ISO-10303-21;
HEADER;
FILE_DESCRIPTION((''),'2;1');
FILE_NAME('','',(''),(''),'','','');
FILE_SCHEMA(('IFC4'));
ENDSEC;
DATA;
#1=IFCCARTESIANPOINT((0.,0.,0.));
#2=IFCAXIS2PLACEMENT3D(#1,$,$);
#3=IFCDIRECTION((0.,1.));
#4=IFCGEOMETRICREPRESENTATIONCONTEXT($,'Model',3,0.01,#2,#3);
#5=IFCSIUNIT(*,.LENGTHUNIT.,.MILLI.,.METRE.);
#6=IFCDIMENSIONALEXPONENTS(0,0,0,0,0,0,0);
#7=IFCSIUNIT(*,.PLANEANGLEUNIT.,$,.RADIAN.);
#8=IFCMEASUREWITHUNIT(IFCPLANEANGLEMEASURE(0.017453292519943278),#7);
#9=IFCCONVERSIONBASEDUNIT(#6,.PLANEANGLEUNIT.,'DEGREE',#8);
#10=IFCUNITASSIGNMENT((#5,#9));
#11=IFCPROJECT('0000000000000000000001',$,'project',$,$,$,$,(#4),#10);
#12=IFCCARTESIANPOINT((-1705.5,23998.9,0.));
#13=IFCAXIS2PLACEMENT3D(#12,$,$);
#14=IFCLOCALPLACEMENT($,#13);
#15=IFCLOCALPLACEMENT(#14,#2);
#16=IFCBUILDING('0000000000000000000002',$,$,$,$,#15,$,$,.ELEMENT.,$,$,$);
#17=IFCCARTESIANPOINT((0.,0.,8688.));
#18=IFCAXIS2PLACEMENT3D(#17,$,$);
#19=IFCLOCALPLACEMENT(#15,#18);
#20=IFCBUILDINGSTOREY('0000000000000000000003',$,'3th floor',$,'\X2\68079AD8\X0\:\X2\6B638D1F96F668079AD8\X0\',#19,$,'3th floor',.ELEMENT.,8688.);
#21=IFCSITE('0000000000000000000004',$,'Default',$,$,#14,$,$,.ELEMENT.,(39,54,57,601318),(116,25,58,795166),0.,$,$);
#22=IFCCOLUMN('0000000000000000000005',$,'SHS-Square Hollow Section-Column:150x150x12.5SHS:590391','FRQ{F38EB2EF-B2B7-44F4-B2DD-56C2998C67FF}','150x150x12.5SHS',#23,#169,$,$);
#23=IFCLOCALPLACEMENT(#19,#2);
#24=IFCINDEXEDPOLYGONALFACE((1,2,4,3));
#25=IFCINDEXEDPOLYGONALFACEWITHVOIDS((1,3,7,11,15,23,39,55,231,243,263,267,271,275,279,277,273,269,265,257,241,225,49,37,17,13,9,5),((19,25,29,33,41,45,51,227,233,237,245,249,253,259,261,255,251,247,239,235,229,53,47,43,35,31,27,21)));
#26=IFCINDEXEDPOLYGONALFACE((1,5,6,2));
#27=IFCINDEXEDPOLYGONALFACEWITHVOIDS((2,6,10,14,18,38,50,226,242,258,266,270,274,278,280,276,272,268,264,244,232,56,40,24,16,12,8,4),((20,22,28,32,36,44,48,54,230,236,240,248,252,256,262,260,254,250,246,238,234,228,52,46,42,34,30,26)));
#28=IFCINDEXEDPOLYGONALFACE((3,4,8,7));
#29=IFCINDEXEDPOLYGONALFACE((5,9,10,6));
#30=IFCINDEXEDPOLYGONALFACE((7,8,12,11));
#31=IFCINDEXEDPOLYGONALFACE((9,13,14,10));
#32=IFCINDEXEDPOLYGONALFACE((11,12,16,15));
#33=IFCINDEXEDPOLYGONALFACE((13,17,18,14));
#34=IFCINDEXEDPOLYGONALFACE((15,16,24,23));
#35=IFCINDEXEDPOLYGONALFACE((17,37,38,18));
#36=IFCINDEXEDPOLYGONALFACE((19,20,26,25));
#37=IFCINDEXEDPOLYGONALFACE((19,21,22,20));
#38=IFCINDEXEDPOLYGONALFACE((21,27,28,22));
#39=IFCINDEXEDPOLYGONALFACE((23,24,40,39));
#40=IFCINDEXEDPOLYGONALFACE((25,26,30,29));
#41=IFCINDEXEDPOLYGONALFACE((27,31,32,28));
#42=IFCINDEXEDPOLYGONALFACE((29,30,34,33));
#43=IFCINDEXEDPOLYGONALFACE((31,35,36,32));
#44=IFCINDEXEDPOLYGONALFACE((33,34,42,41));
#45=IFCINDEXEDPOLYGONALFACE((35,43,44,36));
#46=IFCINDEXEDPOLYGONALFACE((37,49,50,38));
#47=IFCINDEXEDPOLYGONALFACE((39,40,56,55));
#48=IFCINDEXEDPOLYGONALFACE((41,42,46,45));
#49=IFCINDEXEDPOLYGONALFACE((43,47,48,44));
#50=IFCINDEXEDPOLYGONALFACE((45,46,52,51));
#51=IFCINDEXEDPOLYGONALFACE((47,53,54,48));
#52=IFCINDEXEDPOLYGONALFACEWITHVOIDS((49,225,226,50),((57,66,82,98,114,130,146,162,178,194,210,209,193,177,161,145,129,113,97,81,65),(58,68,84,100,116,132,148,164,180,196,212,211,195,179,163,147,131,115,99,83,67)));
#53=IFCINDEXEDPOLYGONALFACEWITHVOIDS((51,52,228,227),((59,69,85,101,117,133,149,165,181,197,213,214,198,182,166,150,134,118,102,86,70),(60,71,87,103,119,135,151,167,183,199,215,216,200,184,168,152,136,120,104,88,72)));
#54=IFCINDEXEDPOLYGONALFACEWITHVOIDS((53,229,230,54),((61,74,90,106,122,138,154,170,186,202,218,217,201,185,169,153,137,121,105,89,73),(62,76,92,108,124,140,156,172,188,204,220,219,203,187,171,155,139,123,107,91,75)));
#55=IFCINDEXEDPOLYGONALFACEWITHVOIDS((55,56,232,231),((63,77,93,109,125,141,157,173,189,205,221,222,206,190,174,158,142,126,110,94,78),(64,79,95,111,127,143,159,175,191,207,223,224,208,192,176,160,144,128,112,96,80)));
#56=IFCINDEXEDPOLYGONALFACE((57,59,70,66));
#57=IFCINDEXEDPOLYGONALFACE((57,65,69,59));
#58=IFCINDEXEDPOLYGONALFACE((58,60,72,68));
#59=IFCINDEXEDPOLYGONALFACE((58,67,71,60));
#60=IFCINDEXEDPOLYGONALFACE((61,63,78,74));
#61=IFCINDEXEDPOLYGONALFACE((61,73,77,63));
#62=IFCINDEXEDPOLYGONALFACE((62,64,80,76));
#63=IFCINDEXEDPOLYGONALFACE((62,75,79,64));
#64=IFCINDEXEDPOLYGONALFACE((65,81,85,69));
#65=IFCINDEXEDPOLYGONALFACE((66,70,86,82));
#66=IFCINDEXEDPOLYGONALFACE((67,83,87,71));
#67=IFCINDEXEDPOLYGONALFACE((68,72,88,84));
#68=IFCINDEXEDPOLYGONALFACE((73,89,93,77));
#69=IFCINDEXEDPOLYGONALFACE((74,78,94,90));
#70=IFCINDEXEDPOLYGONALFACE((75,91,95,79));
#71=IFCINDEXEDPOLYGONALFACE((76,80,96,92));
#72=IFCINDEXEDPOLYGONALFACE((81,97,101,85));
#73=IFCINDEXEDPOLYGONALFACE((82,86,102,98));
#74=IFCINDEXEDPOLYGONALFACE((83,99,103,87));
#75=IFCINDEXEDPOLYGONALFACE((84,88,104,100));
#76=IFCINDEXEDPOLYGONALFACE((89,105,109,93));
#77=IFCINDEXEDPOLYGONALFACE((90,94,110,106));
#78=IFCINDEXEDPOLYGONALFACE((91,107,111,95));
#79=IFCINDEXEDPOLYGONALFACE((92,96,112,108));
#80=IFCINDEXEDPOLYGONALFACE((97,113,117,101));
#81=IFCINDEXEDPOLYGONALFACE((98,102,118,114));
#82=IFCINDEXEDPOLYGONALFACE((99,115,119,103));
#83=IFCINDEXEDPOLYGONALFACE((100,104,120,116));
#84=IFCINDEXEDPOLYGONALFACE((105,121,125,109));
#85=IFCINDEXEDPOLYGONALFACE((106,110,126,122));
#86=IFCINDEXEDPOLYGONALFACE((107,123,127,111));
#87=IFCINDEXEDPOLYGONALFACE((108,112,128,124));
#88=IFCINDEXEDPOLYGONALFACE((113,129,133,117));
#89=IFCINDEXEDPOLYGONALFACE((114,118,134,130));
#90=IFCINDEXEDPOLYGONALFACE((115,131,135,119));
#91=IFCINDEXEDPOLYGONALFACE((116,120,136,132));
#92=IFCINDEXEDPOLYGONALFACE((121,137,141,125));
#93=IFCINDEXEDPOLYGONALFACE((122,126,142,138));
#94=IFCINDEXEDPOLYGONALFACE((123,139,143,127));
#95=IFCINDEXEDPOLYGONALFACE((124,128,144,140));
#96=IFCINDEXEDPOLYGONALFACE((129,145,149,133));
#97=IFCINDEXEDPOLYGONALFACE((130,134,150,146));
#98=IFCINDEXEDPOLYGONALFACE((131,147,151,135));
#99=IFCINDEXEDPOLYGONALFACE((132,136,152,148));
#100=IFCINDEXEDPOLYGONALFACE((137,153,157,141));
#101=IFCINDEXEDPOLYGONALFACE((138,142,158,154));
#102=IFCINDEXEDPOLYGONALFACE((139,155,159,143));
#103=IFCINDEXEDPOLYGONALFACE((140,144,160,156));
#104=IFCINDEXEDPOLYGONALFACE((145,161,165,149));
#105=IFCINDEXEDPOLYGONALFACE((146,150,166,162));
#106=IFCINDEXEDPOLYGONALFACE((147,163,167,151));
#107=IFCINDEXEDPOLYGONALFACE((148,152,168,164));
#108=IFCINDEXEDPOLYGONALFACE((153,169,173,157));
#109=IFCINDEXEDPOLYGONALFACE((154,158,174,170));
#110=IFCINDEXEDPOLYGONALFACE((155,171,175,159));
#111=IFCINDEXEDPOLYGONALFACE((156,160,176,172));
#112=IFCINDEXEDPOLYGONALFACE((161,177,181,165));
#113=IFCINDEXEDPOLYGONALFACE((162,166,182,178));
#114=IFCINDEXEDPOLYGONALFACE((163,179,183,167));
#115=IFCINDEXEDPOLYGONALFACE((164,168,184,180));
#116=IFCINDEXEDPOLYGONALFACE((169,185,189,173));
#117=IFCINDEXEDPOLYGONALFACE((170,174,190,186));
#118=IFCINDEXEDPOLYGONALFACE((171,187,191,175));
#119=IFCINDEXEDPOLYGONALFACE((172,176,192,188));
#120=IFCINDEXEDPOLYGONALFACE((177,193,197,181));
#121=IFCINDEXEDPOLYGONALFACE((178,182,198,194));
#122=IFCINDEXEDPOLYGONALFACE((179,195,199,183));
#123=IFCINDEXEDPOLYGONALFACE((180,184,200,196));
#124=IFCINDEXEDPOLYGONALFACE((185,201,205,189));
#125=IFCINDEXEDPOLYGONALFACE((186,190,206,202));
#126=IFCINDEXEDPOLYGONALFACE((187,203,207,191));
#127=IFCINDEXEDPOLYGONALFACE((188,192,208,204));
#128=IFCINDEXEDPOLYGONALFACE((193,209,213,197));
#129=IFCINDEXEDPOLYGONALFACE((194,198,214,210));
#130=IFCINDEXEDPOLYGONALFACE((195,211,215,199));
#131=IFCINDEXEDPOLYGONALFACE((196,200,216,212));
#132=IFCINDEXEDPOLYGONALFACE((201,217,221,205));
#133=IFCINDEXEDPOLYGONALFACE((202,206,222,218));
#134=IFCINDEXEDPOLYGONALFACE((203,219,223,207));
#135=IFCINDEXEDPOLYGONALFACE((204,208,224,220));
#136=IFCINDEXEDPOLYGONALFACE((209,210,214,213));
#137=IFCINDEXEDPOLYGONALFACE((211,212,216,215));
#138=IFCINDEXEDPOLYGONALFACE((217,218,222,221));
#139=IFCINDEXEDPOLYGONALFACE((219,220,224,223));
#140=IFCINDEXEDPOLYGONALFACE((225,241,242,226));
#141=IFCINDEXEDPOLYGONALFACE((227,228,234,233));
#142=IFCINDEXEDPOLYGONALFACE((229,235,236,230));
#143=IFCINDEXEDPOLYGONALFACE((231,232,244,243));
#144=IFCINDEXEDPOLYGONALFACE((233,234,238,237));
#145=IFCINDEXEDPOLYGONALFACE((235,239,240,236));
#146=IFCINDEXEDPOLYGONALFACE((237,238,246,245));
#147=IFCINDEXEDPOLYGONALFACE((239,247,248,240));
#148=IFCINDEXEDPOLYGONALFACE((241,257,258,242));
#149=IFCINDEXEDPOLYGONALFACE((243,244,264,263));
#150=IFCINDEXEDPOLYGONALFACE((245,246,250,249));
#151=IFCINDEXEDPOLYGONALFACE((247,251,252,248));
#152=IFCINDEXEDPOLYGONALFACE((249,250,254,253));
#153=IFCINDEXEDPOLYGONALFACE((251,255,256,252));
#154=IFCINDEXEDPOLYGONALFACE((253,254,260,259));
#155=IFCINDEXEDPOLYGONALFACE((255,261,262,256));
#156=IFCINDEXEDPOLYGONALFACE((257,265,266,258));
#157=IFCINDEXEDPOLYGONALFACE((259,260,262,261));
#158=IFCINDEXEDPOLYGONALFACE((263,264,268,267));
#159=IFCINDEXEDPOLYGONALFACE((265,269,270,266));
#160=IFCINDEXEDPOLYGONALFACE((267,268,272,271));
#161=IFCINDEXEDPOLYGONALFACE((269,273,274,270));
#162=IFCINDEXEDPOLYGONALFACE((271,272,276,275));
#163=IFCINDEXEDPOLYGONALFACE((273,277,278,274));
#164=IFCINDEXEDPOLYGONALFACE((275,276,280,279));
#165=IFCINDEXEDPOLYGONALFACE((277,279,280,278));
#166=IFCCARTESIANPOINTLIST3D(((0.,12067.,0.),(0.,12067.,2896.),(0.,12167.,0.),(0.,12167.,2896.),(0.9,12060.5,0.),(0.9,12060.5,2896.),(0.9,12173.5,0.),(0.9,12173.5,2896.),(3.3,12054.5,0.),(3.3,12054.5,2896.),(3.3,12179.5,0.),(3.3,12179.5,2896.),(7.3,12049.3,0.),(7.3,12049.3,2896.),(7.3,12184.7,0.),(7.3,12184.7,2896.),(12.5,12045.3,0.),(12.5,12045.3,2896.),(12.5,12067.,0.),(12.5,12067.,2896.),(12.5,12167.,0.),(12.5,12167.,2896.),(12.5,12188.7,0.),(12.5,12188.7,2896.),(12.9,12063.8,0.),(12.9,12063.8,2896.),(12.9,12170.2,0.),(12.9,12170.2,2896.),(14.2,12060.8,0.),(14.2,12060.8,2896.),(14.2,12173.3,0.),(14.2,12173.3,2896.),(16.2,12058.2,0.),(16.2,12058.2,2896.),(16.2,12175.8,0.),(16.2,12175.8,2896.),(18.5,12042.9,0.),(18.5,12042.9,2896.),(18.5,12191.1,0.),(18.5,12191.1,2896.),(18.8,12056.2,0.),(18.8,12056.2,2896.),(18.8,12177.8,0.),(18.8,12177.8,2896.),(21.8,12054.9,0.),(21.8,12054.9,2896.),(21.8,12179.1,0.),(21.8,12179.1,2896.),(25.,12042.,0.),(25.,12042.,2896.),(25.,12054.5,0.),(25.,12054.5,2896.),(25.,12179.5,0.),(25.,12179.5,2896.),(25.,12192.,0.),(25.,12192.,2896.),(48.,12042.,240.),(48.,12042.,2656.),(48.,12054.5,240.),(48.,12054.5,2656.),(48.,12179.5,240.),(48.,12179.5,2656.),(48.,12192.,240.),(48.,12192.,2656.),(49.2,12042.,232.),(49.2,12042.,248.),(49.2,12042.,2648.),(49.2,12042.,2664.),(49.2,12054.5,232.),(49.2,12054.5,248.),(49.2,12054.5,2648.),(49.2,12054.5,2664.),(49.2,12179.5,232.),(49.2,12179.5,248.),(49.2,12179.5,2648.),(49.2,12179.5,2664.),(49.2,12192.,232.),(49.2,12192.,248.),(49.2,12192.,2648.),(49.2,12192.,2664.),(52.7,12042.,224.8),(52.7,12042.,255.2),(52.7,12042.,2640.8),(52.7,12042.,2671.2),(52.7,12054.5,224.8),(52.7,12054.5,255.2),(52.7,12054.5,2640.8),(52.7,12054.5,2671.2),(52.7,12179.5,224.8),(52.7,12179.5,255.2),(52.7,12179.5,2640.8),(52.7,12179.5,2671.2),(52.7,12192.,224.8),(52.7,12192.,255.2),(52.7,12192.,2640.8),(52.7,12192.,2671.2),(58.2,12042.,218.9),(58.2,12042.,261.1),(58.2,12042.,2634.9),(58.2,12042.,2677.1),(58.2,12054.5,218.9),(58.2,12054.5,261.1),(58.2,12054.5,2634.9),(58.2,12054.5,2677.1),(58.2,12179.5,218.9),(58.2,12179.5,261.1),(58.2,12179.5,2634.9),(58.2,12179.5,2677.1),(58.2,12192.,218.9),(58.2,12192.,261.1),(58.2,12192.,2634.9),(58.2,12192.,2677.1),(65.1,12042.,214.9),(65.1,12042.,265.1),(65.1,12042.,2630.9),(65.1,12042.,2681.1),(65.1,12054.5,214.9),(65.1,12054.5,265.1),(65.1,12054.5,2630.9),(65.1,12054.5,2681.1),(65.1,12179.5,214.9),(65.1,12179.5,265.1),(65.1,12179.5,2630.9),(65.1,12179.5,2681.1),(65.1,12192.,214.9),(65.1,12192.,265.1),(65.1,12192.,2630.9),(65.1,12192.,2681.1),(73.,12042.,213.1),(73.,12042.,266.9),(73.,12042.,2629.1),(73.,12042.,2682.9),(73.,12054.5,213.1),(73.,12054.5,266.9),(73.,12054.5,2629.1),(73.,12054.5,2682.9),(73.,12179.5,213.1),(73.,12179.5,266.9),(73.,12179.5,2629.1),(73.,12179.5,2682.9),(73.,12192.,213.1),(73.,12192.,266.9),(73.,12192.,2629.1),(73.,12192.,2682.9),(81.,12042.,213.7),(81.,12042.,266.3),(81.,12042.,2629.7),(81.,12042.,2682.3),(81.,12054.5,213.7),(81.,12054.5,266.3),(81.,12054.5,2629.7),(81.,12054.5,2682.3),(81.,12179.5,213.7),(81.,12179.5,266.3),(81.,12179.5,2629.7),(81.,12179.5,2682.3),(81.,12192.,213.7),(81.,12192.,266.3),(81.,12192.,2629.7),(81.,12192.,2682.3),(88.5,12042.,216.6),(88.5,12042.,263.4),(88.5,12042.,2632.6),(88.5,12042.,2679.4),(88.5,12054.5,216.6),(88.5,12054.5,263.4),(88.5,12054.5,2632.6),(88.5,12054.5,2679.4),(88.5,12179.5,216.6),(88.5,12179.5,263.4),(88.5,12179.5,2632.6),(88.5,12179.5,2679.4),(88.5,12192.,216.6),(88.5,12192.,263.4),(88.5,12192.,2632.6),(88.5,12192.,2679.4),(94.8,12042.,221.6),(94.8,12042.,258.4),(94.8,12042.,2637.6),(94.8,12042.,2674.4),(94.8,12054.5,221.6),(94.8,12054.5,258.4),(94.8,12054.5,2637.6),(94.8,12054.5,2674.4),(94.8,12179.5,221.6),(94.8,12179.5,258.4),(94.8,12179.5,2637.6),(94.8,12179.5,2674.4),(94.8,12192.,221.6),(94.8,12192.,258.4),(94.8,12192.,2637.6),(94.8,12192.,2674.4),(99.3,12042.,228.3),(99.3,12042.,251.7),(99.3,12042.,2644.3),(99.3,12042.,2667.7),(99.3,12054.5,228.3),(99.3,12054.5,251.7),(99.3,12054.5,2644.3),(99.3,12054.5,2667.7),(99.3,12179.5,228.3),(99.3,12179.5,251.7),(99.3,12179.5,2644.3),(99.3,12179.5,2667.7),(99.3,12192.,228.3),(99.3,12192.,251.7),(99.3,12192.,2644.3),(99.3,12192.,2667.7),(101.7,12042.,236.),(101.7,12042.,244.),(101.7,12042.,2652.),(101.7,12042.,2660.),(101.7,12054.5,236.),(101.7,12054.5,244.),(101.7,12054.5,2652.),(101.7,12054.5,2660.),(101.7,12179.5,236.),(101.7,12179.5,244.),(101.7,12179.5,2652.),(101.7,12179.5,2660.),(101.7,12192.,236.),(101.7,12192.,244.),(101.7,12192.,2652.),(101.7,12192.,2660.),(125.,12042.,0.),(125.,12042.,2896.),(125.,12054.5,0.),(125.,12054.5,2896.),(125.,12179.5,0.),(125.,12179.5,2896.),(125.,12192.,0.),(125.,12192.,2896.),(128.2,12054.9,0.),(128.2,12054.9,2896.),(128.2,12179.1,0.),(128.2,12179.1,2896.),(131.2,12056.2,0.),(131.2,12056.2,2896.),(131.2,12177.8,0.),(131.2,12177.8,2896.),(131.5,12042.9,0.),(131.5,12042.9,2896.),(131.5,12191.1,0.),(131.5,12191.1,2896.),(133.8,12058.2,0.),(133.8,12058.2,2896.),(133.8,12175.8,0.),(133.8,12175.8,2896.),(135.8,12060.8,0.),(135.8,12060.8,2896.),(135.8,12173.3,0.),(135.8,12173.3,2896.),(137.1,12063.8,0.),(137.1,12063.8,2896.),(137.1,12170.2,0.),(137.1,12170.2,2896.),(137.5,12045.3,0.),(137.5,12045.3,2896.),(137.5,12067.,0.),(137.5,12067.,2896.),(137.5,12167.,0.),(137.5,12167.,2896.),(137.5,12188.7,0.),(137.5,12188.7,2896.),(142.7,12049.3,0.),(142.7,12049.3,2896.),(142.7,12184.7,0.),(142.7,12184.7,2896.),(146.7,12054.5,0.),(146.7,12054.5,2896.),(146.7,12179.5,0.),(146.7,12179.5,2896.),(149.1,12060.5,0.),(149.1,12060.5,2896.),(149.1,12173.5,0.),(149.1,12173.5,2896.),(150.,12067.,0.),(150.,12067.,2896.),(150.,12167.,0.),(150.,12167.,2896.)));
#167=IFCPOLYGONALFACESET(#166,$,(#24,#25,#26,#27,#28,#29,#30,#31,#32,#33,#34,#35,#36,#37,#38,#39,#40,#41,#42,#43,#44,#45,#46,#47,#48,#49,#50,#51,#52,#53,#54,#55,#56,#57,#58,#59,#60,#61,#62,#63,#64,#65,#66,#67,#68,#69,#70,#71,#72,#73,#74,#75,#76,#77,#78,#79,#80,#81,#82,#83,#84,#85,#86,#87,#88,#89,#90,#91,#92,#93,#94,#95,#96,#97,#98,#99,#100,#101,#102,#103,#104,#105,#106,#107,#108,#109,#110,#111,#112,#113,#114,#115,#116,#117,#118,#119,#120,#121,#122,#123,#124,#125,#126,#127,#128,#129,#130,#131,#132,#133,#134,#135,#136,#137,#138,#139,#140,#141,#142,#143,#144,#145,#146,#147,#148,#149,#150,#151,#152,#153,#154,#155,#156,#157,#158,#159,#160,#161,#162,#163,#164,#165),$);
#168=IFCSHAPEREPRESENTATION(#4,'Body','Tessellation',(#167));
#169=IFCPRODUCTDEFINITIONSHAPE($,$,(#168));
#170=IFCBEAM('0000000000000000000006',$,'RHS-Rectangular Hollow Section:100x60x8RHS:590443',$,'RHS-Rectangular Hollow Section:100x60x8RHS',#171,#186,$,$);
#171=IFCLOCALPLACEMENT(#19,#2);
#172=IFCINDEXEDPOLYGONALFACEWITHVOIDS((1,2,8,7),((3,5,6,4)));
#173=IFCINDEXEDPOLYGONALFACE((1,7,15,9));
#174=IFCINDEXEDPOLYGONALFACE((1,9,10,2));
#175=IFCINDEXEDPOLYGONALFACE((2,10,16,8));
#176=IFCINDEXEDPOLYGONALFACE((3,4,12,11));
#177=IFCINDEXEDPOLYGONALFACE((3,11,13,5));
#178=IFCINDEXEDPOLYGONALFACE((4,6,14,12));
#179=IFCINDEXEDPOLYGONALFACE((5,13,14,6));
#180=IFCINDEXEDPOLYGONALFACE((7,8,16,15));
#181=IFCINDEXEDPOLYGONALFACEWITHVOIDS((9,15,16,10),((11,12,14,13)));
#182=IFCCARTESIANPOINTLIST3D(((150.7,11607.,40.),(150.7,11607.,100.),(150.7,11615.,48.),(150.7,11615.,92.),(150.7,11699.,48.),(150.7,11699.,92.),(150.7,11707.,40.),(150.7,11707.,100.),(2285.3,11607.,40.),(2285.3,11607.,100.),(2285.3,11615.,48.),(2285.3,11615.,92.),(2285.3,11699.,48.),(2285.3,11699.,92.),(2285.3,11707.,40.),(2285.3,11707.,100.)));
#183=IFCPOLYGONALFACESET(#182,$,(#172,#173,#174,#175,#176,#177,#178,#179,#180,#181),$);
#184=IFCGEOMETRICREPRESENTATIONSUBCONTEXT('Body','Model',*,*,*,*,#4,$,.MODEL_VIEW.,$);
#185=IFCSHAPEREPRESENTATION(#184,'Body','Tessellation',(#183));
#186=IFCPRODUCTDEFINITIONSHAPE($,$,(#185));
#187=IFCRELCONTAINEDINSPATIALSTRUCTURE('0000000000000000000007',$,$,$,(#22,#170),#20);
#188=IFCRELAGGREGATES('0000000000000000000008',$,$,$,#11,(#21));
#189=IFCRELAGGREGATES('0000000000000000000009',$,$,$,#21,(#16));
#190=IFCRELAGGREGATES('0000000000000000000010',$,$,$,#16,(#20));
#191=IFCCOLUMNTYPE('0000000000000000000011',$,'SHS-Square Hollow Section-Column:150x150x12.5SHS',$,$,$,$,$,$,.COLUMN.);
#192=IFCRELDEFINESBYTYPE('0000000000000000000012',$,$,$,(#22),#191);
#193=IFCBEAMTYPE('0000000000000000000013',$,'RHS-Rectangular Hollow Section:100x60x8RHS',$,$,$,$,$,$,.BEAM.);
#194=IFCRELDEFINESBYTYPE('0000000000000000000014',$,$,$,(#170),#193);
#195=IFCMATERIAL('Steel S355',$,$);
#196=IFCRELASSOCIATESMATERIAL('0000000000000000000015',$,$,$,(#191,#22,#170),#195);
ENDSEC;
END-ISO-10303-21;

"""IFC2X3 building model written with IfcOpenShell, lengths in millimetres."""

from ifc_helpers import new_model, entity, si_unit, converted_unit, direction, frame, frame_2d, origin, origin_2d, place, context, subcontext, project, spatial, circle_curve, rectangle, hollow_rectangle, outline, extrude, boolean, material, type_object, element, save


model = new_model("IFC2X3")

# Units and contexts
model_context = context("Model", 3, precision=0.01, world=origin(), true_north=direction((0.0, 1.0)))
body_context = subcontext(model_context, "Body", "Model", "MODEL_VIEW")
ifc_project = project(units=[si_unit("LENGTHUNIT", "METRE", prefix="MILLI"), converted_unit("PLANEANGLEUNIT", "DEGREE", entity("IfcPlaneAngleMeasure", 0.017453292519943278), si_unit("PLANEANGLEUNIT", "RADIAN"), dimensions=[0, 0, 0, 0, 0, 0, 0])], contexts=[model_context])

# Site, building, storey
site_placement = place(None, frame((-1705.5, 23998.9, 0.0)))
site = spatial("IfcSite", under=ifc_project, at=site_placement, Name="Default", CompositionType="ELEMENT", RefLatitude=(39, 54, 57, 601318), RefLongitude=(116, 25, 58, 795166), RefElevation=0.0)
building_placement = place(site_placement, origin())
building = spatial("IfcBuilding", under=site, at=building_placement, CompositionType="ELEMENT")
storey_placement = place(building_placement, frame((0.0, 0.0, 8688.0)))
storey = spatial("IfcBuildingStorey", under=building, at=storey_placement, Name="3th floor", ObjectType="标高:正负零标高", LongName="3th floor", CompositionType="ELEMENT", Elevation=8688.0)

# Shared definitions
ifc_material_1 = material(Name="Steel S355")

# Column, openings
column_type_1 = type_object("IfcColumnType", Name="SHS-Square Hollow Section-Column:150x150x12.5SHS", PredefinedType="COLUMN", material=ifc_material_1)
column_1_placement = place(storey_placement, frame((75.0, 12117.0, 2896.0), z_axis=(0.0, 0.0, 1.0), x_axis=(0.0, -1.0, 0.0)))
column_1 = element("IfcColumn", 1, at=column_1_placement, inside=storey, type_object=column_type_1, material=ifc_material_1, Name="SHS-Square Hollow Section-Column:150x150x12.5SHS:590391", Description="FRQ{F38EB2EF-B2B7-44F4-B2DD-56C2998C67FF}", ObjectType="150x150x12.5SHS", context=model_context, shape_type="SweptSolid", body=[
    extrude(hollow_rectangle(XDim=150.0, YDim=150.0, WallThickness=12.5, InnerFilletRadius=12.5, OuterFilletRadius=25.0, at=origin_2d()), origin(), (0.0, 0.0, -1.0), 2896.0),
])
opening_1_placement = place(column_1_placement, frame((175.1, 0.0, -2896.0), z_axis=(-1.0, 0.0, 0.0), x_axis=(0.0, -1.0, 0.0)))
element("IfcOpeningElement", 2, at=opening_1_placement, cuts=column_1, ObjectType="Opening", context=model_context, shape_type="SweptSolid", body=[
    extrude(outline(circle_curve(frame_2d((0.0, 240.0), x_axis=(1.0, 0.0)), 27.0)), origin(), (0.0, 0.0, 1.0), 350.2),
])
opening_2_placement = place(column_1_placement, frame((175.1, 0.0, 0.0), z_axis=(-1.0, 0.0, 0.0), x_axis=(0.0, -1.0, 0.0)))
element("IfcOpeningElement", 3, at=opening_2_placement, cuts=column_1, ObjectType="Opening", context=model_context, shape_type="SweptSolid", body=[
    extrude(outline(circle_curve(frame_2d((0.0, -240.0), x_axis=(1.0, 0.0)), 27.0)), origin(), (0.0, 0.0, 1.0), 350.2),
])

# Beam
beam_type_1 = type_object("IfcBeamType", Name="RHS-Rectangular Hollow Section:100x60x8RHS", PredefinedType="BEAM")
beam_1_placement = place(storey_placement, frame((150.7, 11707.0, 70.0)))
element("IfcBeam", 4, at=beam_1_placement, inside=storey, type_object=beam_type_1, material=ifc_material_1, Name="RHS-Rectangular Hollow Section:100x60x8RHS:590443", ObjectType="RHS-Rectangular Hollow Section:100x60x8RHS", context=body_context, shape_type="SweptSolid", body=[
    boolean("DIFFERENCE", extrude(rectangle(XDim=60.0, YDim=100.0, at=frame_2d((0.0, 0.0), x_axis=(1.0, 0.0))), frame((0.0, -50.0, 0.0), z_axis=(1.0, 0.0, 0.0), x_axis=(0.0, 0.0, -1.0)), (0.0, 0.0, 1.0), 2134.6), extrude(rectangle(XDim=44.0, YDim=84.0, at=frame_2d((0.0, 0.0), x_axis=(0.0, 1.0))), frame((2134.6, -50.0, 0.0), z_axis=(-1.0, 0.0, 0.0), x_axis=(0.0, 1.0, 0.0)), (0.0, 0.0, 1.0), 2134.6)),
])

save(model, "model.ifc")
